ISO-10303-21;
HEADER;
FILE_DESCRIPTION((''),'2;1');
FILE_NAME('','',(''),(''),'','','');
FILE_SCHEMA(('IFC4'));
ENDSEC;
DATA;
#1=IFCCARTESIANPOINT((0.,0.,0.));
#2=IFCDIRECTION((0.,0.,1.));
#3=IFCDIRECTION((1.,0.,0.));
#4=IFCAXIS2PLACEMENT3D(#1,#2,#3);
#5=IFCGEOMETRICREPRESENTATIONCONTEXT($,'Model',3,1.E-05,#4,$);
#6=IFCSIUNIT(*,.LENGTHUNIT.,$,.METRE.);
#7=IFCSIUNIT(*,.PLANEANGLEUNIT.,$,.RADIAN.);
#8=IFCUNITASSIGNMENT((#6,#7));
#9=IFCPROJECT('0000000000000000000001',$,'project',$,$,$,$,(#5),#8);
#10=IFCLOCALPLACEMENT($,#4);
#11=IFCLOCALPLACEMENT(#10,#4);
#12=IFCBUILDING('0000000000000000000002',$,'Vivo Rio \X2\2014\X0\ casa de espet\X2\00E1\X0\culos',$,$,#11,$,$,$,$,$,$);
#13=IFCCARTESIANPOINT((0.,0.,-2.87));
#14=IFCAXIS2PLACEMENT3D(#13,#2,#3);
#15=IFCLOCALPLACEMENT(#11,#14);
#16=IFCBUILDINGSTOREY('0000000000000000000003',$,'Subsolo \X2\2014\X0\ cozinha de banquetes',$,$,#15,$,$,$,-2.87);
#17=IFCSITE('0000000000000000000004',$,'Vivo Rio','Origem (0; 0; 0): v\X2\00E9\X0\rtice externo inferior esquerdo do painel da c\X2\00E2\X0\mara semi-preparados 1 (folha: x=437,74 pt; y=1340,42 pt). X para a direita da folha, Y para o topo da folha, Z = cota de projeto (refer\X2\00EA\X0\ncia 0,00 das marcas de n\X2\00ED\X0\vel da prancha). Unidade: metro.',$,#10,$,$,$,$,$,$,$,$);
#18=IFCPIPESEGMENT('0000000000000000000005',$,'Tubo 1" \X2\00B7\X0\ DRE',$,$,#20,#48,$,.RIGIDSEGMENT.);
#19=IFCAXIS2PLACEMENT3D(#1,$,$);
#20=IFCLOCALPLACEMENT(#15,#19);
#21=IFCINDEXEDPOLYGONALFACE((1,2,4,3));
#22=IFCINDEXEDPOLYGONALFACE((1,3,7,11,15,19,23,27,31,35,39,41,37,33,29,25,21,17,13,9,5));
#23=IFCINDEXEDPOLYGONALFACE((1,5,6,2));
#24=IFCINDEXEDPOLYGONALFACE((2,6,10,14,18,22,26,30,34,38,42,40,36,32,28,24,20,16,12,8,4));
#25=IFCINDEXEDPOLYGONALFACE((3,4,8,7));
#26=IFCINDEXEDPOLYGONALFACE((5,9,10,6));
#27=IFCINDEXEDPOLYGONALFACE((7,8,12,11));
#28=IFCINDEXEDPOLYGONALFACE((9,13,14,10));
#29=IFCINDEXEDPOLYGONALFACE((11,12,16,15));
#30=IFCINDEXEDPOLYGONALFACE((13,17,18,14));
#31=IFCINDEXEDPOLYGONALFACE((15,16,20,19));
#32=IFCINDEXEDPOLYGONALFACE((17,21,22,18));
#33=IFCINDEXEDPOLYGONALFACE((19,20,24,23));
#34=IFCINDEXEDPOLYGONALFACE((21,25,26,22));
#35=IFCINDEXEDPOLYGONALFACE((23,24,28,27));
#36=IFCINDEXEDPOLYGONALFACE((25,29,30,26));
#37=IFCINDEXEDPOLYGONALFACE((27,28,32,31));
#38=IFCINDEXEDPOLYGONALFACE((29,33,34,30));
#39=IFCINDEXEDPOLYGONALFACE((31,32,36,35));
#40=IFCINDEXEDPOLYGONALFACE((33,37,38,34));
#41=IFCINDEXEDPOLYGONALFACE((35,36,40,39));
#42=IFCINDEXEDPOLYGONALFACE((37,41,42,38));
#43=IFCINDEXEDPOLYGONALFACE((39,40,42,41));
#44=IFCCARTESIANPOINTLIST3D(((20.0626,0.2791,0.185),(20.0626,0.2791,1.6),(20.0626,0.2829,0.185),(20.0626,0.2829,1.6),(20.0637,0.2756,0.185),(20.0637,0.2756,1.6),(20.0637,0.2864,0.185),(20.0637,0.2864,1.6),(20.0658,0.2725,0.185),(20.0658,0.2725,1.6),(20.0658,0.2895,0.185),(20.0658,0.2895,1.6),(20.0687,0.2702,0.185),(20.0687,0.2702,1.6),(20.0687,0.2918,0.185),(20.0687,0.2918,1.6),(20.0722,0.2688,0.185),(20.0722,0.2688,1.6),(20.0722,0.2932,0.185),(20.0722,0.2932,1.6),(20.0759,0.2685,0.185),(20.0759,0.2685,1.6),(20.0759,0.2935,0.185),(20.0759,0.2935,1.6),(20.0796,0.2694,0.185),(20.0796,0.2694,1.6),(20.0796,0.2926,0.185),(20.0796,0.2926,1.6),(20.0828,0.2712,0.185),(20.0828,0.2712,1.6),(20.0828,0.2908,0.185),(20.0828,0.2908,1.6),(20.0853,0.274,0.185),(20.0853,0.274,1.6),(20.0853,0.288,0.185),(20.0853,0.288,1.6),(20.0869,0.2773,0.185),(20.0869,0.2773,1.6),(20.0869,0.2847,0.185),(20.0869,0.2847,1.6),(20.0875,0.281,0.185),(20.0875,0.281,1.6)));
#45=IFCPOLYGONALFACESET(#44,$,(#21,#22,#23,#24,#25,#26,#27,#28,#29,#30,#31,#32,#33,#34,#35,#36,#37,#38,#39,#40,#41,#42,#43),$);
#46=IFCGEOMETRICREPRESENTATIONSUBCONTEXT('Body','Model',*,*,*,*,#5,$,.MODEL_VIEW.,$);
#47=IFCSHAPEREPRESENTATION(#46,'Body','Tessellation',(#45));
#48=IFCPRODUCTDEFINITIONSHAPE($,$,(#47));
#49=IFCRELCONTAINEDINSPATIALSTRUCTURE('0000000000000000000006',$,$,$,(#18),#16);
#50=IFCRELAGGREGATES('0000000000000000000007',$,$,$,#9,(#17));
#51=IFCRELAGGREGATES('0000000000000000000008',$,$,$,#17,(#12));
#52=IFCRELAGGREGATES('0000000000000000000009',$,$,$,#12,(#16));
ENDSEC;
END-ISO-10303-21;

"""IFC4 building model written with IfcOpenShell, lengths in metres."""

from ifc_helpers import new_model, si_unit, frame, origin_with_axes, origin_2d, place, context, subcontext, project, spatial, circle, extrude, element, save


model = new_model("IFC4")

# Units and contexts
model_context = context("Model", 3, precision=1e-05, world=origin_with_axes())
body_context = subcontext(model_context, "Body", "Model", "MODEL_VIEW")
ifc_project = project(units=[si_unit("LENGTHUNIT", "METRE"), si_unit("PLANEANGLEUNIT", "RADIAN")], contexts=[model_context])

# Site, building, storey
site_placement = place(None, origin_with_axes())
site = spatial("IfcSite", under=ifc_project, at=site_placement, Name="Vivo Rio", Description="Origem (0; 0; 0): vértice externo inferior esquerdo do painel da câmara semi-preparados 1 (folha: x=437,74 pt; y=1340,42 pt). X para a direita da folha, Y para o topo da folha, Z = cota de projeto (referência 0,00 das marcas de nível da prancha). Unidade: metro.")
building_placement = place(site_placement, origin_with_axes())
building = spatial("IfcBuilding", under=site, at=building_placement, Name="Vivo Rio — casa de espetáculos")
storey_placement = place(building_placement, frame((0.0, 0.0, -2.87), z_axis=(0.0, 0.0, 1.0), x_axis=(1.0, 0.0, 0.0)))
storey = spatial("IfcBuildingStorey", under=building, at=storey_placement, Name="Subsolo — cozinha de banquetes", Elevation=-2.87)

# Pipe segment
pipe_segment_1_placement = place(storey_placement, origin_with_axes())
element("IfcPipeSegment", 1, at=pipe_segment_1_placement, inside=storey, Name="Tubo 1\" · DRE", PredefinedType="RIGIDSEGMENT", context=body_context, shape_type="SweptSolid", body=[
    extrude(circle(Radius=0.0125, at=origin_2d()), frame((20.075, 0.281, 1.6), z_axis=(0.0, 0.0, -1.0), x_axis=(1.0, 0.0, 0.0)), (0.0, 0.0, 1.0), 1.415),
])

save(model, "model.ifc")
